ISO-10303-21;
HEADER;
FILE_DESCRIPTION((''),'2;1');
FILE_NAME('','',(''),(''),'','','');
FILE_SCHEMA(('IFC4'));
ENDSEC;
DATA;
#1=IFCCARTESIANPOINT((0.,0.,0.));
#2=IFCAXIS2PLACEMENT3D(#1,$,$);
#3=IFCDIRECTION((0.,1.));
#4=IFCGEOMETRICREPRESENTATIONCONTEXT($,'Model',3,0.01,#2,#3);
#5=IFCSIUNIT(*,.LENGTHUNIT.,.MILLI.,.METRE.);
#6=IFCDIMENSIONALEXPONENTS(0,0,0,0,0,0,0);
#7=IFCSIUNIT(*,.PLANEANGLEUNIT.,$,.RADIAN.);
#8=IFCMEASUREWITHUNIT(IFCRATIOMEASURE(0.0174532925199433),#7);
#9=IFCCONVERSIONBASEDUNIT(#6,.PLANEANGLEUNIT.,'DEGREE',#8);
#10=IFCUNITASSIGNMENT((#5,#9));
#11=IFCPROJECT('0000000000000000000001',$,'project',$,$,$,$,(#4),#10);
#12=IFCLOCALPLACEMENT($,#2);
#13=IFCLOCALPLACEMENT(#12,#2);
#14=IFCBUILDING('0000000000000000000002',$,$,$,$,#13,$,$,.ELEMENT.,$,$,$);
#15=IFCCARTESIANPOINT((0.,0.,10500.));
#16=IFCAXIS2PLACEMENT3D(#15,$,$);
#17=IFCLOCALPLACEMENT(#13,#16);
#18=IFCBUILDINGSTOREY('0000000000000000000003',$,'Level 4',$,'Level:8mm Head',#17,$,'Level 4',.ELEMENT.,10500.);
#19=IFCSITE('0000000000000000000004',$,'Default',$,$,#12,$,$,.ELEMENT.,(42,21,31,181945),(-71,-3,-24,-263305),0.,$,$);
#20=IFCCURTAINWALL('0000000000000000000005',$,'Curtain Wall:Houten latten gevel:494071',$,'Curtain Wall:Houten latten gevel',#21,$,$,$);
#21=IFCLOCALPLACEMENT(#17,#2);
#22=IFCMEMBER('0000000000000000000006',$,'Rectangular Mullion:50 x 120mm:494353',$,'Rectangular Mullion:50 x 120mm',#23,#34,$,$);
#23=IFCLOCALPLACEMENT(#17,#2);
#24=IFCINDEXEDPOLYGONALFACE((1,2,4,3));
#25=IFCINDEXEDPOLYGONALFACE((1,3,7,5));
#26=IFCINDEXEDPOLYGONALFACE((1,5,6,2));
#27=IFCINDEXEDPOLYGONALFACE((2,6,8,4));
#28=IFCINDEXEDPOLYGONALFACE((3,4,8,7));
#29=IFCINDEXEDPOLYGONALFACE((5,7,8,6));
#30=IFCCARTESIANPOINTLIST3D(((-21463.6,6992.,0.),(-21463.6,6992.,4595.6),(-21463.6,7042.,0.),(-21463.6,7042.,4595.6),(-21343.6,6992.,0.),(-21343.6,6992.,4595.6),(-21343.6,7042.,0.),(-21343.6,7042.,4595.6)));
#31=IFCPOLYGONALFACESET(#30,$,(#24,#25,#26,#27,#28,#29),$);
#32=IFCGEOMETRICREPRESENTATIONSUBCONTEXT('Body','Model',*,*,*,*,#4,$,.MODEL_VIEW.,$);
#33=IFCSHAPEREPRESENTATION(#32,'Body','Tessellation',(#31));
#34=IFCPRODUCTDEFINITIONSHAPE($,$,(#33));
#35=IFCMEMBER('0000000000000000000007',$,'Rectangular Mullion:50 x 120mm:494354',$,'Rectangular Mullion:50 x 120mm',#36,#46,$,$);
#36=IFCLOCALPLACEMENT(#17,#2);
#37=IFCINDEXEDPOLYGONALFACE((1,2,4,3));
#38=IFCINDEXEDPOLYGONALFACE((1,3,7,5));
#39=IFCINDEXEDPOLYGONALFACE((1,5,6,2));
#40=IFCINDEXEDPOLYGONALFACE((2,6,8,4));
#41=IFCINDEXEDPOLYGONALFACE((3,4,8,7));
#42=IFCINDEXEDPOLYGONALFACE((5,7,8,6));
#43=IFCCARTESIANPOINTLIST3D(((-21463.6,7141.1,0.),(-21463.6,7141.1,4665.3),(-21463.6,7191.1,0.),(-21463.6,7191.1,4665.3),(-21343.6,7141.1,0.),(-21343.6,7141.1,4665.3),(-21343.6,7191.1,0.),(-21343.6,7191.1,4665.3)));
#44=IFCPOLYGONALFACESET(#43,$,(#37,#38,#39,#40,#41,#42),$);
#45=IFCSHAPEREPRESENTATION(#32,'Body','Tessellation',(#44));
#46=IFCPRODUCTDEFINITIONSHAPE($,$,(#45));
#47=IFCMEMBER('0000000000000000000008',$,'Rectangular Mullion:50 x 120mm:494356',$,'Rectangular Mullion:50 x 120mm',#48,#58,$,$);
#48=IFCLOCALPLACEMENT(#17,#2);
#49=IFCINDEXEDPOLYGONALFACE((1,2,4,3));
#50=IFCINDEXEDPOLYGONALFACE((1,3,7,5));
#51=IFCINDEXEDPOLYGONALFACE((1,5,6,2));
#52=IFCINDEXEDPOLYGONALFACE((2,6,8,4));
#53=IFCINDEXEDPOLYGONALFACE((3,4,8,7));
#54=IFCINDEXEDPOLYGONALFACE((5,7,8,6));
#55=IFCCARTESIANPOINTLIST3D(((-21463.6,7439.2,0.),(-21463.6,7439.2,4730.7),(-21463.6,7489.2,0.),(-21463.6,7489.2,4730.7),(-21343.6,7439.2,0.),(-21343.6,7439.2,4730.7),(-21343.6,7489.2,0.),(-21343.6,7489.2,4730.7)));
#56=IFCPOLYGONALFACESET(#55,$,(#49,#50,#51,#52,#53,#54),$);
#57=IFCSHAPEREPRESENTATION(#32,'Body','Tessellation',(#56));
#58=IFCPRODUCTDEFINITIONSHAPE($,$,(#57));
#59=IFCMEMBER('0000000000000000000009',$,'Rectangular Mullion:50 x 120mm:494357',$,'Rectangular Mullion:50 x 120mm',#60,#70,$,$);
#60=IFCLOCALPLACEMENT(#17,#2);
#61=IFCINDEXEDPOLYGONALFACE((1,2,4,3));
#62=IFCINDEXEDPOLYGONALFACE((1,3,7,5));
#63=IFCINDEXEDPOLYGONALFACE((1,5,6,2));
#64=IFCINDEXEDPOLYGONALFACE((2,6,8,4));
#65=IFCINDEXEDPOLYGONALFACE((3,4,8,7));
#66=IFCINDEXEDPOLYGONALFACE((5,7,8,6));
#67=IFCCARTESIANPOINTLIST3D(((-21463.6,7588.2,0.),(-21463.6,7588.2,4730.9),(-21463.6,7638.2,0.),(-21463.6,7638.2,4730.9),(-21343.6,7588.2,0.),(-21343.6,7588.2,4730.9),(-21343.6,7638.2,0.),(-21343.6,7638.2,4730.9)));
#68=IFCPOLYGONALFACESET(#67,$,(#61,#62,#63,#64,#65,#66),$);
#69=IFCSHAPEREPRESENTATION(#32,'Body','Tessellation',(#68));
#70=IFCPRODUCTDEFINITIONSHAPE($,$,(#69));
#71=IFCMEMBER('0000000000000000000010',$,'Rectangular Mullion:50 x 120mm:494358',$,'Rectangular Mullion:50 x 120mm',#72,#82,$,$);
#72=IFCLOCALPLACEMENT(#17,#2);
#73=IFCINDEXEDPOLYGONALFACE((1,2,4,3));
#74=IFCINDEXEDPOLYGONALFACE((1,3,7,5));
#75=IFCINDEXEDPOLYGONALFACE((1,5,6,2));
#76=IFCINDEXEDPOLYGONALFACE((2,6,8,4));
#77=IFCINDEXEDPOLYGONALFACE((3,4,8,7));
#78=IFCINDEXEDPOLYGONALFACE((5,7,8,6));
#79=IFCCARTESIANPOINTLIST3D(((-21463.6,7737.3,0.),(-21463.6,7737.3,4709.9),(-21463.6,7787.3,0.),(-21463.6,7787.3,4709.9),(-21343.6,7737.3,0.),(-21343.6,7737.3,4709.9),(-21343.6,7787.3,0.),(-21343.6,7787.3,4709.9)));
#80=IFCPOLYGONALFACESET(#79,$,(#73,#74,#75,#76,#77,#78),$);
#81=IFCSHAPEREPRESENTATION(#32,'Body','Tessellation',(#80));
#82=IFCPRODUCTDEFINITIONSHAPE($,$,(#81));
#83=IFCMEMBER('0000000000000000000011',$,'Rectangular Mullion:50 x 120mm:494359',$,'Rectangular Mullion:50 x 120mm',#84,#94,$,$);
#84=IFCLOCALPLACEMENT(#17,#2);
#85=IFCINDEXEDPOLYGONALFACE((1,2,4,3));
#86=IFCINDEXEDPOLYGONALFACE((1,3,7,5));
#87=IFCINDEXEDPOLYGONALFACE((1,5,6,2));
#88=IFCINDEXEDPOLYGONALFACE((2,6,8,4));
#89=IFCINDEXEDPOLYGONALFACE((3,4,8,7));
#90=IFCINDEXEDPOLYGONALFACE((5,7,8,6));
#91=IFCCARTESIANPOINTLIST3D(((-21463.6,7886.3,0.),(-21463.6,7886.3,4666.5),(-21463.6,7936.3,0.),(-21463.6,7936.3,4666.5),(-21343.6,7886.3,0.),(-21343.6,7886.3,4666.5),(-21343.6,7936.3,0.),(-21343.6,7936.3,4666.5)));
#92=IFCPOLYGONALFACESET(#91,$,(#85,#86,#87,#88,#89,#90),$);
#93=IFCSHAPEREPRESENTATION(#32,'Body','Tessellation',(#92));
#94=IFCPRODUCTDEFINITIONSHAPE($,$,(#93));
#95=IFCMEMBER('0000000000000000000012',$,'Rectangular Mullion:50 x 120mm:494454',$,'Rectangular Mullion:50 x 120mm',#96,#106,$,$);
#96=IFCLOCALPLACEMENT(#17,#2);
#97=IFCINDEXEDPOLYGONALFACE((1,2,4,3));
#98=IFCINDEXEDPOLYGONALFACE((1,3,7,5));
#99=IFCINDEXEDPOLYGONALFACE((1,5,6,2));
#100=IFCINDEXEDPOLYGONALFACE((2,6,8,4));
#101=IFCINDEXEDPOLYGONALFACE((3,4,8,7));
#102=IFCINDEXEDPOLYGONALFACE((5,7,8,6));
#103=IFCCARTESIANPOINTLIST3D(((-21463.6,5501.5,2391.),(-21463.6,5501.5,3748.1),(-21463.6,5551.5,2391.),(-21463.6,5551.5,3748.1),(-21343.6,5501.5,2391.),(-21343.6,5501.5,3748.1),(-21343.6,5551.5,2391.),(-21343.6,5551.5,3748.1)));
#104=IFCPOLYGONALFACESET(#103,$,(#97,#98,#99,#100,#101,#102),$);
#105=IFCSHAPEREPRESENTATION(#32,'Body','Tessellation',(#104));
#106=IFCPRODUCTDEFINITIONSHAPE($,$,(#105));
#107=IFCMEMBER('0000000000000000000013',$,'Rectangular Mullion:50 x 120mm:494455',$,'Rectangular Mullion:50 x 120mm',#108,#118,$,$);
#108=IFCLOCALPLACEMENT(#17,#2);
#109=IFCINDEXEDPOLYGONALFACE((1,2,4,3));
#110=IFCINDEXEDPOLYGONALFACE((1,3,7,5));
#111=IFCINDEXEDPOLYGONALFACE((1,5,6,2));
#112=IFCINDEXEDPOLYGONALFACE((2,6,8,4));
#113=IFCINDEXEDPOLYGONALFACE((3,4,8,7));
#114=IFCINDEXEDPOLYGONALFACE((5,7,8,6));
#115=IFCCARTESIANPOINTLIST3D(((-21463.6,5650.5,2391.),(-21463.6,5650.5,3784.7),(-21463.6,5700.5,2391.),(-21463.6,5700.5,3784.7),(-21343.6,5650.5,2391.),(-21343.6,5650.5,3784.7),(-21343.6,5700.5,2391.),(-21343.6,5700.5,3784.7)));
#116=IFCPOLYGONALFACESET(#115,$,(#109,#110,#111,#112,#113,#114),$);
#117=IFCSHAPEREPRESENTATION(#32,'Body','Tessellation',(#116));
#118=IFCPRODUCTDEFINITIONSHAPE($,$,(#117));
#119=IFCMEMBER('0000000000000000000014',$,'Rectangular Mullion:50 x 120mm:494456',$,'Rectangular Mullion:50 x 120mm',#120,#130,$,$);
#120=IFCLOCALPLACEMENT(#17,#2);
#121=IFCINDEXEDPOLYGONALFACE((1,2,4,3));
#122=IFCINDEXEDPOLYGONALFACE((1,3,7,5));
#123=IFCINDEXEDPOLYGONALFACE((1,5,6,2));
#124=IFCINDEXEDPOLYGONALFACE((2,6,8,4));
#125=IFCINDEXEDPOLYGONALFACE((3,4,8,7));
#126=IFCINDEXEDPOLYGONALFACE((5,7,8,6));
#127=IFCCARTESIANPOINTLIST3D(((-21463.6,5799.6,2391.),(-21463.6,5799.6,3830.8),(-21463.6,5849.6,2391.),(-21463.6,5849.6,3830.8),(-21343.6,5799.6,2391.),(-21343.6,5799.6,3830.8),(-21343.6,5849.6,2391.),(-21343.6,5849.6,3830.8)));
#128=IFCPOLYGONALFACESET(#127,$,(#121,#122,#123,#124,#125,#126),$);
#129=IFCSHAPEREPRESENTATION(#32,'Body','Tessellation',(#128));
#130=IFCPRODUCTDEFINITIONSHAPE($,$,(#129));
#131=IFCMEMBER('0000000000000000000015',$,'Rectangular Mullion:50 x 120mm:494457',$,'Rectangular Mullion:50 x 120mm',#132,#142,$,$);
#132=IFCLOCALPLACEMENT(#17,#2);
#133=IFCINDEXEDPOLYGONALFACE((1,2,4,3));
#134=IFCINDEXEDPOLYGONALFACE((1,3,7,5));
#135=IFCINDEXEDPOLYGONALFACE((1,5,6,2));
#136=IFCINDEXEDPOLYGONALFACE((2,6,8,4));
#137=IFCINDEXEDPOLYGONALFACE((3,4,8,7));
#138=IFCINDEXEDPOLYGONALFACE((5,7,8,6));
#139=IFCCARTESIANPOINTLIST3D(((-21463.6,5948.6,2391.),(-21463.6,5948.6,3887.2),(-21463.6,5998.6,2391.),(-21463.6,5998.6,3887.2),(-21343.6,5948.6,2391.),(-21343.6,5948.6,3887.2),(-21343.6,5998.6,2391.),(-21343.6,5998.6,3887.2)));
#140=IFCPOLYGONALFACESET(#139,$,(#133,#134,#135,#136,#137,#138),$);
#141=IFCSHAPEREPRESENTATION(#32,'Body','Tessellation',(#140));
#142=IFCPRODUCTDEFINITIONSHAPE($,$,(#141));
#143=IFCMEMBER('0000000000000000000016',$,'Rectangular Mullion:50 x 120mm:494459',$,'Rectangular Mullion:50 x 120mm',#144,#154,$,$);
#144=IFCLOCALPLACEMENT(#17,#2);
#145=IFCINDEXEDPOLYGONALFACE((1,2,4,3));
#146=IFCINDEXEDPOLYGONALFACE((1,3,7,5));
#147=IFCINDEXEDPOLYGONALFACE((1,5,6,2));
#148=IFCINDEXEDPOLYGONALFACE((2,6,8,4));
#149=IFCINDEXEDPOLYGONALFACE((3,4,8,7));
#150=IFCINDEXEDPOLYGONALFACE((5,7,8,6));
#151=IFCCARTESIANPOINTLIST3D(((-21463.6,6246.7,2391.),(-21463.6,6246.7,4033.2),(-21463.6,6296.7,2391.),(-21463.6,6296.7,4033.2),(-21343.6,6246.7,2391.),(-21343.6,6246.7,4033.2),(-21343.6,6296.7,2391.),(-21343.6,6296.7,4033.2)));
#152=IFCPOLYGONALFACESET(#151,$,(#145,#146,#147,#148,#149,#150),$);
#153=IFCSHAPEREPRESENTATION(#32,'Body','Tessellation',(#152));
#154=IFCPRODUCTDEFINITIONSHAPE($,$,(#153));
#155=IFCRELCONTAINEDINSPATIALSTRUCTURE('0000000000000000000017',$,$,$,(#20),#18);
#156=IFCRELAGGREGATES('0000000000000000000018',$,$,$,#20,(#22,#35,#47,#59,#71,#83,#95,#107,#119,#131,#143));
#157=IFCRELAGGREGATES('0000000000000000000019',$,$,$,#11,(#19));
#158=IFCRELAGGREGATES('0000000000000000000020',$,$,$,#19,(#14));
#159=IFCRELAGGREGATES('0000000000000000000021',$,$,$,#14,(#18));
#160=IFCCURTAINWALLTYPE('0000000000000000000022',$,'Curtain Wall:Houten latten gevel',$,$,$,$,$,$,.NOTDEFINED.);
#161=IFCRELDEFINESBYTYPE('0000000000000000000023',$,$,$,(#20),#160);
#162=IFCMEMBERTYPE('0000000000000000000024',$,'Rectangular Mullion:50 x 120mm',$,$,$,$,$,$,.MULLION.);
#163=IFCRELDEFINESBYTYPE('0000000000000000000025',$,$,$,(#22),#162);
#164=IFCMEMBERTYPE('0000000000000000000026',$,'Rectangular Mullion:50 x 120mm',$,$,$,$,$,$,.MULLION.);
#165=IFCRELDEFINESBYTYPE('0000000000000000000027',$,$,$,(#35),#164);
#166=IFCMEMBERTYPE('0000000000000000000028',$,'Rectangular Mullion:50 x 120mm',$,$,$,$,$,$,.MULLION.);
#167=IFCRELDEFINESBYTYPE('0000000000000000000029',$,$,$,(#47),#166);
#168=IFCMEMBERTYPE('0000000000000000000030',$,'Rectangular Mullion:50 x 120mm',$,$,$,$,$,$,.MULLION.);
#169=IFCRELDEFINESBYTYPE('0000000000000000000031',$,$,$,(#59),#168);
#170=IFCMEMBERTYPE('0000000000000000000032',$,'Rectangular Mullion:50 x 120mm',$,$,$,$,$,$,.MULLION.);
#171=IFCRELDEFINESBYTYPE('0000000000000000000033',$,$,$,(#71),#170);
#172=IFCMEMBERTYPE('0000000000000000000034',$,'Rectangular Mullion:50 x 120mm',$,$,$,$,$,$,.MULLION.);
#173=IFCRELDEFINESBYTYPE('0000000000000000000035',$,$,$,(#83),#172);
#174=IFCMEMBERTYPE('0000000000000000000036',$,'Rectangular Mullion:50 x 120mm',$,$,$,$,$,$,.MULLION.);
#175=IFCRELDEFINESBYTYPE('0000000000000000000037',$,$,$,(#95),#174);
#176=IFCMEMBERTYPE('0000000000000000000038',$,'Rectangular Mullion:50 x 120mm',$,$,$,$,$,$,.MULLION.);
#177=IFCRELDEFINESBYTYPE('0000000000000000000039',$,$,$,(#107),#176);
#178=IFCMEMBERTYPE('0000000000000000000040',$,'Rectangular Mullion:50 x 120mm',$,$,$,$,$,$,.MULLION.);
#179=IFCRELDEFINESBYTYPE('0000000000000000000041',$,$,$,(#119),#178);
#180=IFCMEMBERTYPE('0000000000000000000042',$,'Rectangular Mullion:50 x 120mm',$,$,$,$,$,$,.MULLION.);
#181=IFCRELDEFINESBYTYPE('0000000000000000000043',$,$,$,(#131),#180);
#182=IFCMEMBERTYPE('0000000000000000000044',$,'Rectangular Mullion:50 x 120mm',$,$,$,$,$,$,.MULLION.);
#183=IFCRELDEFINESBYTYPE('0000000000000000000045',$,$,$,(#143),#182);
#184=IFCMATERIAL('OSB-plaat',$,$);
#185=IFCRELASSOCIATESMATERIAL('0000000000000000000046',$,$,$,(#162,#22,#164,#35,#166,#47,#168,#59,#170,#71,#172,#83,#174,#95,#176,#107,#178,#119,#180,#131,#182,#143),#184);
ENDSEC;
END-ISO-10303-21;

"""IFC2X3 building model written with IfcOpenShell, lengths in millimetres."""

from ifc_helpers import new_model, entity, si_unit, converted_unit, direction, frame, origin, origin_2d_with_axis, place, context, subcontext, project, spatial, rectangle, extrude, source, transform, mapped, material, type_object, type_shapes, element, aggregate, save


model = new_model("IFC2X3")

# Units and contexts
model_context = context("Model", 3, precision=0.01, world=origin(), true_north=direction((0.0, 1.0)))
body_context = subcontext(model_context, "Body", "Model", "MODEL_VIEW")
ifc_project = project(units=[si_unit("LENGTHUNIT", "METRE", prefix="MILLI"), converted_unit("PLANEANGLEUNIT", "DEGREE", entity("IfcRatioMeasure", 0.0174532925199433), si_unit("PLANEANGLEUNIT", "RADIAN"), dimensions=[0, 0, 0, 0, 0, 0, 0])], contexts=[model_context])

# Site, building, storey
site_placement = place(None, frame((0.0, 0.0, 0.0)))
site = spatial("IfcSite", under=ifc_project, at=site_placement, Name="Default", CompositionType="ELEMENT", RefLatitude=(42, 21, 31, 181945), RefLongitude=(-71, -3, -24, -263305), RefElevation=0.0)
building_placement = place(site_placement, origin())
building = spatial("IfcBuilding", under=site, at=building_placement, CompositionType="ELEMENT")
storey_placement = place(building_placement, frame((0.0, 0.0, 10500.0)))
storey = spatial("IfcBuildingStorey", under=building, at=storey_placement, Name="Level 4", ObjectType="Level:8mm Head", LongName="Level 4", CompositionType="ELEMENT", Elevation=10500.0)

# Curtain wall, members
curtain_wall_type = type_object("IfcCurtainWallType", Name="Curtain Wall:Houten latten gevel", PredefinedType="NOTDEFINED")
curtain_wall_placement = place(storey_placement, frame((0.0, 0.0, -10500.0)))
curtain_wall = element("IfcCurtainWall", 1, at=curtain_wall_placement, inside=storey, type_object=curtain_wall_type, Name="Curtain Wall:Houten latten gevel:494071", ObjectType="Curtain Wall:Houten latten gevel")
ifc_material_1 = material(Name="OSB-plaat")
placement = place(building_placement, frame((0.0, 0.0, 7500.0)))
member_type_1 = type_object("IfcMemberType", Name="Rectangular Mullion:50 x 120mm", PredefinedType="MULLION", material=ifc_material_1)
shared_shape_1 = source(origin(), body_context, "Body", "SweptSolid", [
    extrude(rectangle(XDim=120.0, YDim=50.0, at=origin_2d_with_axis()), frame((0.0, 0.0, -4595.6), z_axis=(0.0, 0.0, 1.0), x_axis=(0.0, -1.0, 0.0)), (0.0, 0.0, 1.0), 4595.6),
])
type_shapes(member_type_1, [shared_shape_1])
member_1_placement = place(placement, frame((-21403.6, 7017.0, 3000.0), z_axis=(0.0, 0.0, -1.0), x_axis=(0.0, 1.0, 0.0)))
member_1 = element("IfcMember", 2, at=member_1_placement, type_object=member_type_1, material=ifc_material_1, Name="Rectangular Mullion:50 x 120mm:494353", ObjectType="Rectangular Mullion:50 x 120mm", context=body_context, shape_type="MappedRepresentation", body=[
    mapped(shared_shape_1, transform((0.0, 0.0, 0.0), scale=1.0)),
])
member_type_2 = type_object("IfcMemberType", Name="Rectangular Mullion:50 x 120mm", PredefinedType="MULLION", material=ifc_material_1)
shared_shape_2 = source(origin(), body_context, "Body", "SweptSolid", [
    extrude(rectangle(XDim=120.0, YDim=50.0, at=origin_2d_with_axis()), frame((0.0, 0.0, -4665.3), z_axis=(0.0, 0.0, 1.0), x_axis=(0.0, -1.0, 0.0)), (0.0, 0.0, 1.0), 4665.3),
])
type_shapes(member_type_2, [shared_shape_2])
member_2_placement = place(placement, frame((-21403.6, 7166.1, 3000.0), z_axis=(0.0, 0.0, -1.0), x_axis=(0.0, 1.0, 0.0)))
member_2 = element("IfcMember", 3, at=member_2_placement, type_object=member_type_2, material=ifc_material_1, Name="Rectangular Mullion:50 x 120mm:494354", ObjectType="Rectangular Mullion:50 x 120mm", context=body_context, shape_type="MappedRepresentation", body=[
    mapped(shared_shape_2, transform((0.0, 0.0, 0.0), scale=1.0)),
])
member_type_3 = type_object("IfcMemberType", Name="Rectangular Mullion:50 x 120mm", PredefinedType="MULLION", material=ifc_material_1)
shared_shape_3 = source(origin(), body_context, "Body", "SweptSolid", [
    extrude(rectangle(XDim=120.0, YDim=50.0, at=origin_2d_with_axis()), frame((0.0, 0.0, -4730.7), z_axis=(0.0, 0.0, 1.0), x_axis=(0.0, -1.0, 0.0)), (0.0, 0.0, 1.0), 4730.7),
])
type_shapes(member_type_3, [shared_shape_3])
member_3_placement = place(placement, frame((-21403.6, 7464.2, 3000.0), z_axis=(0.0, 0.0, -1.0), x_axis=(0.0, 1.0, 0.0)))
member_3 = element("IfcMember", 4, at=member_3_placement, type_object=member_type_3, material=ifc_material_1, Name="Rectangular Mullion:50 x 120mm:494356", ObjectType="Rectangular Mullion:50 x 120mm", context=body_context, shape_type="MappedRepresentation", body=[
    mapped(shared_shape_3, transform((0.0, 0.0, 0.0), scale=1.0)),
])
member_type_4 = type_object("IfcMemberType", Name="Rectangular Mullion:50 x 120mm", PredefinedType="MULLION", material=ifc_material_1)
shared_shape_4 = source(origin(), body_context, "Body", "SweptSolid", [
    extrude(rectangle(XDim=120.0, YDim=50.0, at=origin_2d_with_axis()), frame((0.0, 0.0, -4730.9), z_axis=(0.0, 0.0, 1.0), x_axis=(0.0, -1.0, 0.0)), (0.0, 0.0, 1.0), 4730.9),
])
type_shapes(member_type_4, [shared_shape_4])
member_4_placement = place(placement, frame((-21403.6, 7613.2, 3000.0), z_axis=(0.0, 0.0, -1.0), x_axis=(0.0, 1.0, 0.0)))
member_4 = element("IfcMember", 5, at=member_4_placement, type_object=member_type_4, material=ifc_material_1, Name="Rectangular Mullion:50 x 120mm:494357", ObjectType="Rectangular Mullion:50 x 120mm", context=body_context, shape_type="MappedRepresentation", body=[
    mapped(shared_shape_4, transform((0.0, 0.0, 0.0), scale=1.0)),
])
member_type_5 = type_object("IfcMemberType", Name="Rectangular Mullion:50 x 120mm", PredefinedType="MULLION", material=ifc_material_1)
shared_shape_5 = source(origin(), body_context, "Body", "SweptSolid", [
    extrude(rectangle(XDim=120.0, YDim=50.0, at=origin_2d_with_axis()), frame((0.0, 0.0, -4709.9), z_axis=(0.0, 0.0, 1.0), x_axis=(0.0, -1.0, 0.0)), (0.0, 0.0, 1.0), 4709.9),
])
type_shapes(member_type_5, [shared_shape_5])
member_5_placement = place(placement, frame((-21403.6, 7762.3, 3000.0), z_axis=(0.0, 0.0, -1.0), x_axis=(0.0, 1.0, 0.0)))
member_5 = element("IfcMember", 6, at=member_5_placement, type_object=member_type_5, material=ifc_material_1, Name="Rectangular Mullion:50 x 120mm:494358", ObjectType="Rectangular Mullion:50 x 120mm", context=body_context, shape_type="MappedRepresentation", body=[
    mapped(shared_shape_5, transform((0.0, 0.0, 0.0), scale=1.0)),
])
member_type_6 = type_object("IfcMemberType", Name="Rectangular Mullion:50 x 120mm", PredefinedType="MULLION", material=ifc_material_1)
shared_shape_6 = source(origin(), body_context, "Body", "SweptSolid", [
    extrude(rectangle(XDim=120.0, YDim=50.0, at=origin_2d_with_axis()), frame((0.0, 0.0, -4666.5), z_axis=(0.0, 0.0, 1.0), x_axis=(0.0, -1.0, 0.0)), (0.0, 0.0, 1.0), 4666.5),
])
type_shapes(member_type_6, [shared_shape_6])
member_6_placement = place(placement, frame((-21403.6, 7911.3, 3000.0), z_axis=(0.0, 0.0, -1.0), x_axis=(0.0, 1.0, 0.0)))
member_6 = element("IfcMember", 7, at=member_6_placement, type_object=member_type_6, material=ifc_material_1, Name="Rectangular Mullion:50 x 120mm:494359", ObjectType="Rectangular Mullion:50 x 120mm", context=body_context, shape_type="MappedRepresentation", body=[
    mapped(shared_shape_6, transform((0.0, 0.0, 0.0), scale=1.0)),
])
member_type_7 = type_object("IfcMemberType", Name="Rectangular Mullion:50 x 120mm", PredefinedType="MULLION", material=ifc_material_1)
shared_shape_7 = source(origin(), body_context, "Body", "SweptSolid", [
    extrude(rectangle(XDim=120.0, YDim=50.0, at=origin_2d_with_axis()), frame((0.0, 0.0, -1357.1), z_axis=(0.0, 0.0, 1.0), x_axis=(0.0, -1.0, 0.0)), (0.0, 0.0, 1.0), 1357.1),
])
type_shapes(member_type_7, [shared_shape_7])
member_7_placement = place(placement, frame((-21403.6, 5526.5, 5391.0), z_axis=(0.0, 0.0, -1.0), x_axis=(0.0, 1.0, 0.0)))
member_7 = element("IfcMember", 8, at=member_7_placement, type_object=member_type_7, material=ifc_material_1, Name="Rectangular Mullion:50 x 120mm:494454", ObjectType="Rectangular Mullion:50 x 120mm", context=body_context, shape_type="MappedRepresentation", body=[
    mapped(shared_shape_7, transform((0.0, 0.0, 0.0), scale=1.0)),
])
member_type_8 = type_object("IfcMemberType", Name="Rectangular Mullion:50 x 120mm", PredefinedType="MULLION", material=ifc_material_1)
shared_shape_8 = source(origin(), body_context, "Body", "SweptSolid", [
    extrude(rectangle(XDim=120.0, YDim=50.0, at=origin_2d_with_axis()), frame((0.0, 0.0, -1393.7), z_axis=(0.0, 0.0, 1.0), x_axis=(0.0, -1.0, 0.0)), (0.0, 0.0, 1.0), 1393.7),
])
type_shapes(member_type_8, [shared_shape_8])
member_8_placement = place(placement, frame((-21403.6, 5675.5, 5391.0), z_axis=(0.0, 0.0, -1.0), x_axis=(0.0, 1.0, 0.0)))
member_8 = element("IfcMember", 9, at=member_8_placement, type_object=member_type_8, material=ifc_material_1, Name="Rectangular Mullion:50 x 120mm:494455", ObjectType="Rectangular Mullion:50 x 120mm", context=body_context, shape_type="MappedRepresentation", body=[
    mapped(shared_shape_8, transform((0.0, 0.0, 0.0), scale=1.0)),
])
member_type_9 = type_object("IfcMemberType", Name="Rectangular Mullion:50 x 120mm", PredefinedType="MULLION", material=ifc_material_1)
shared_shape_9 = source(origin(), body_context, "Body", "SweptSolid", [
    extrude(rectangle(XDim=120.0, YDim=50.0, at=origin_2d_with_axis()), frame((0.0, 0.0, -1439.8), z_axis=(0.0, 0.0, 1.0), x_axis=(0.0, -1.0, 0.0)), (0.0, 0.0, 1.0), 1439.8),
])
type_shapes(member_type_9, [shared_shape_9])
member_9_placement = place(placement, frame((-21403.6, 5824.6, 5391.0), z_axis=(0.0, 0.0, -1.0), x_axis=(0.0, 1.0, 0.0)))
member_9 = element("IfcMember", 10, at=member_9_placement, type_object=member_type_9, material=ifc_material_1, Name="Rectangular Mullion:50 x 120mm:494456", ObjectType="Rectangular Mullion:50 x 120mm", context=body_context, shape_type="MappedRepresentation", body=[
    mapped(shared_shape_9, transform((0.0, 0.0, 0.0), scale=1.0)),
])
member_type_10 = type_object("IfcMemberType", Name="Rectangular Mullion:50 x 120mm", PredefinedType="MULLION", material=ifc_material_1)
shared_shape_10 = source(origin(), body_context, "Body", "SweptSolid", [
    extrude(rectangle(XDim=120.0, YDim=50.0, at=origin_2d_with_axis()), frame((0.0, 0.0, -1496.2), z_axis=(0.0, 0.0, 1.0), x_axis=(0.0, -1.0, 0.0)), (0.0, 0.0, 1.0), 1496.2),
])
type_shapes(member_type_10, [shared_shape_10])
member_10_placement = place(placement, frame((-21403.6, 5973.6, 5391.0), z_axis=(0.0, 0.0, -1.0), x_axis=(0.0, 1.0, 0.0)))
member_10 = element("IfcMember", 11, at=member_10_placement, type_object=member_type_10, material=ifc_material_1, Name="Rectangular Mullion:50 x 120mm:494457", ObjectType="Rectangular Mullion:50 x 120mm", context=body_context, shape_type="MappedRepresentation", body=[
    mapped(shared_shape_10, transform((0.0, 0.0, 0.0), scale=1.0)),
])
member_type_11 = type_object("IfcMemberType", Name="Rectangular Mullion:50 x 120mm", PredefinedType="MULLION", material=ifc_material_1)
shared_shape_11 = source(origin(), body_context, "Body", "SweptSolid", [
    extrude(rectangle(XDim=120.0, YDim=50.0, at=origin_2d_with_axis()), frame((0.0, 0.0, -1642.2), z_axis=(0.0, 0.0, 1.0), x_axis=(0.0, -1.0, 0.0)), (0.0, 0.0, 1.0), 1642.2),
])
type_shapes(member_type_11, [shared_shape_11])
member_11_placement = place(placement, frame((-21403.6, 6271.7, 5391.0), z_axis=(0.0, 0.0, -1.0), x_axis=(0.0, 1.0, 0.0)))
member_11 = element("IfcMember", 12, at=member_11_placement, type_object=member_type_11, material=ifc_material_1, Name="Rectangular Mullion:50 x 120mm:494459", ObjectType="Rectangular Mullion:50 x 120mm", context=body_context, shape_type="MappedRepresentation", body=[
    mapped(shared_shape_11, transform((0.0, 0.0, 0.0), scale=1.0)),
])
aggregate(curtain_wall, [member_1, member_2, member_3, member_4, member_5, member_6, member_7, member_8, member_9, member_10, member_11])

save(model, "model.ifc")
